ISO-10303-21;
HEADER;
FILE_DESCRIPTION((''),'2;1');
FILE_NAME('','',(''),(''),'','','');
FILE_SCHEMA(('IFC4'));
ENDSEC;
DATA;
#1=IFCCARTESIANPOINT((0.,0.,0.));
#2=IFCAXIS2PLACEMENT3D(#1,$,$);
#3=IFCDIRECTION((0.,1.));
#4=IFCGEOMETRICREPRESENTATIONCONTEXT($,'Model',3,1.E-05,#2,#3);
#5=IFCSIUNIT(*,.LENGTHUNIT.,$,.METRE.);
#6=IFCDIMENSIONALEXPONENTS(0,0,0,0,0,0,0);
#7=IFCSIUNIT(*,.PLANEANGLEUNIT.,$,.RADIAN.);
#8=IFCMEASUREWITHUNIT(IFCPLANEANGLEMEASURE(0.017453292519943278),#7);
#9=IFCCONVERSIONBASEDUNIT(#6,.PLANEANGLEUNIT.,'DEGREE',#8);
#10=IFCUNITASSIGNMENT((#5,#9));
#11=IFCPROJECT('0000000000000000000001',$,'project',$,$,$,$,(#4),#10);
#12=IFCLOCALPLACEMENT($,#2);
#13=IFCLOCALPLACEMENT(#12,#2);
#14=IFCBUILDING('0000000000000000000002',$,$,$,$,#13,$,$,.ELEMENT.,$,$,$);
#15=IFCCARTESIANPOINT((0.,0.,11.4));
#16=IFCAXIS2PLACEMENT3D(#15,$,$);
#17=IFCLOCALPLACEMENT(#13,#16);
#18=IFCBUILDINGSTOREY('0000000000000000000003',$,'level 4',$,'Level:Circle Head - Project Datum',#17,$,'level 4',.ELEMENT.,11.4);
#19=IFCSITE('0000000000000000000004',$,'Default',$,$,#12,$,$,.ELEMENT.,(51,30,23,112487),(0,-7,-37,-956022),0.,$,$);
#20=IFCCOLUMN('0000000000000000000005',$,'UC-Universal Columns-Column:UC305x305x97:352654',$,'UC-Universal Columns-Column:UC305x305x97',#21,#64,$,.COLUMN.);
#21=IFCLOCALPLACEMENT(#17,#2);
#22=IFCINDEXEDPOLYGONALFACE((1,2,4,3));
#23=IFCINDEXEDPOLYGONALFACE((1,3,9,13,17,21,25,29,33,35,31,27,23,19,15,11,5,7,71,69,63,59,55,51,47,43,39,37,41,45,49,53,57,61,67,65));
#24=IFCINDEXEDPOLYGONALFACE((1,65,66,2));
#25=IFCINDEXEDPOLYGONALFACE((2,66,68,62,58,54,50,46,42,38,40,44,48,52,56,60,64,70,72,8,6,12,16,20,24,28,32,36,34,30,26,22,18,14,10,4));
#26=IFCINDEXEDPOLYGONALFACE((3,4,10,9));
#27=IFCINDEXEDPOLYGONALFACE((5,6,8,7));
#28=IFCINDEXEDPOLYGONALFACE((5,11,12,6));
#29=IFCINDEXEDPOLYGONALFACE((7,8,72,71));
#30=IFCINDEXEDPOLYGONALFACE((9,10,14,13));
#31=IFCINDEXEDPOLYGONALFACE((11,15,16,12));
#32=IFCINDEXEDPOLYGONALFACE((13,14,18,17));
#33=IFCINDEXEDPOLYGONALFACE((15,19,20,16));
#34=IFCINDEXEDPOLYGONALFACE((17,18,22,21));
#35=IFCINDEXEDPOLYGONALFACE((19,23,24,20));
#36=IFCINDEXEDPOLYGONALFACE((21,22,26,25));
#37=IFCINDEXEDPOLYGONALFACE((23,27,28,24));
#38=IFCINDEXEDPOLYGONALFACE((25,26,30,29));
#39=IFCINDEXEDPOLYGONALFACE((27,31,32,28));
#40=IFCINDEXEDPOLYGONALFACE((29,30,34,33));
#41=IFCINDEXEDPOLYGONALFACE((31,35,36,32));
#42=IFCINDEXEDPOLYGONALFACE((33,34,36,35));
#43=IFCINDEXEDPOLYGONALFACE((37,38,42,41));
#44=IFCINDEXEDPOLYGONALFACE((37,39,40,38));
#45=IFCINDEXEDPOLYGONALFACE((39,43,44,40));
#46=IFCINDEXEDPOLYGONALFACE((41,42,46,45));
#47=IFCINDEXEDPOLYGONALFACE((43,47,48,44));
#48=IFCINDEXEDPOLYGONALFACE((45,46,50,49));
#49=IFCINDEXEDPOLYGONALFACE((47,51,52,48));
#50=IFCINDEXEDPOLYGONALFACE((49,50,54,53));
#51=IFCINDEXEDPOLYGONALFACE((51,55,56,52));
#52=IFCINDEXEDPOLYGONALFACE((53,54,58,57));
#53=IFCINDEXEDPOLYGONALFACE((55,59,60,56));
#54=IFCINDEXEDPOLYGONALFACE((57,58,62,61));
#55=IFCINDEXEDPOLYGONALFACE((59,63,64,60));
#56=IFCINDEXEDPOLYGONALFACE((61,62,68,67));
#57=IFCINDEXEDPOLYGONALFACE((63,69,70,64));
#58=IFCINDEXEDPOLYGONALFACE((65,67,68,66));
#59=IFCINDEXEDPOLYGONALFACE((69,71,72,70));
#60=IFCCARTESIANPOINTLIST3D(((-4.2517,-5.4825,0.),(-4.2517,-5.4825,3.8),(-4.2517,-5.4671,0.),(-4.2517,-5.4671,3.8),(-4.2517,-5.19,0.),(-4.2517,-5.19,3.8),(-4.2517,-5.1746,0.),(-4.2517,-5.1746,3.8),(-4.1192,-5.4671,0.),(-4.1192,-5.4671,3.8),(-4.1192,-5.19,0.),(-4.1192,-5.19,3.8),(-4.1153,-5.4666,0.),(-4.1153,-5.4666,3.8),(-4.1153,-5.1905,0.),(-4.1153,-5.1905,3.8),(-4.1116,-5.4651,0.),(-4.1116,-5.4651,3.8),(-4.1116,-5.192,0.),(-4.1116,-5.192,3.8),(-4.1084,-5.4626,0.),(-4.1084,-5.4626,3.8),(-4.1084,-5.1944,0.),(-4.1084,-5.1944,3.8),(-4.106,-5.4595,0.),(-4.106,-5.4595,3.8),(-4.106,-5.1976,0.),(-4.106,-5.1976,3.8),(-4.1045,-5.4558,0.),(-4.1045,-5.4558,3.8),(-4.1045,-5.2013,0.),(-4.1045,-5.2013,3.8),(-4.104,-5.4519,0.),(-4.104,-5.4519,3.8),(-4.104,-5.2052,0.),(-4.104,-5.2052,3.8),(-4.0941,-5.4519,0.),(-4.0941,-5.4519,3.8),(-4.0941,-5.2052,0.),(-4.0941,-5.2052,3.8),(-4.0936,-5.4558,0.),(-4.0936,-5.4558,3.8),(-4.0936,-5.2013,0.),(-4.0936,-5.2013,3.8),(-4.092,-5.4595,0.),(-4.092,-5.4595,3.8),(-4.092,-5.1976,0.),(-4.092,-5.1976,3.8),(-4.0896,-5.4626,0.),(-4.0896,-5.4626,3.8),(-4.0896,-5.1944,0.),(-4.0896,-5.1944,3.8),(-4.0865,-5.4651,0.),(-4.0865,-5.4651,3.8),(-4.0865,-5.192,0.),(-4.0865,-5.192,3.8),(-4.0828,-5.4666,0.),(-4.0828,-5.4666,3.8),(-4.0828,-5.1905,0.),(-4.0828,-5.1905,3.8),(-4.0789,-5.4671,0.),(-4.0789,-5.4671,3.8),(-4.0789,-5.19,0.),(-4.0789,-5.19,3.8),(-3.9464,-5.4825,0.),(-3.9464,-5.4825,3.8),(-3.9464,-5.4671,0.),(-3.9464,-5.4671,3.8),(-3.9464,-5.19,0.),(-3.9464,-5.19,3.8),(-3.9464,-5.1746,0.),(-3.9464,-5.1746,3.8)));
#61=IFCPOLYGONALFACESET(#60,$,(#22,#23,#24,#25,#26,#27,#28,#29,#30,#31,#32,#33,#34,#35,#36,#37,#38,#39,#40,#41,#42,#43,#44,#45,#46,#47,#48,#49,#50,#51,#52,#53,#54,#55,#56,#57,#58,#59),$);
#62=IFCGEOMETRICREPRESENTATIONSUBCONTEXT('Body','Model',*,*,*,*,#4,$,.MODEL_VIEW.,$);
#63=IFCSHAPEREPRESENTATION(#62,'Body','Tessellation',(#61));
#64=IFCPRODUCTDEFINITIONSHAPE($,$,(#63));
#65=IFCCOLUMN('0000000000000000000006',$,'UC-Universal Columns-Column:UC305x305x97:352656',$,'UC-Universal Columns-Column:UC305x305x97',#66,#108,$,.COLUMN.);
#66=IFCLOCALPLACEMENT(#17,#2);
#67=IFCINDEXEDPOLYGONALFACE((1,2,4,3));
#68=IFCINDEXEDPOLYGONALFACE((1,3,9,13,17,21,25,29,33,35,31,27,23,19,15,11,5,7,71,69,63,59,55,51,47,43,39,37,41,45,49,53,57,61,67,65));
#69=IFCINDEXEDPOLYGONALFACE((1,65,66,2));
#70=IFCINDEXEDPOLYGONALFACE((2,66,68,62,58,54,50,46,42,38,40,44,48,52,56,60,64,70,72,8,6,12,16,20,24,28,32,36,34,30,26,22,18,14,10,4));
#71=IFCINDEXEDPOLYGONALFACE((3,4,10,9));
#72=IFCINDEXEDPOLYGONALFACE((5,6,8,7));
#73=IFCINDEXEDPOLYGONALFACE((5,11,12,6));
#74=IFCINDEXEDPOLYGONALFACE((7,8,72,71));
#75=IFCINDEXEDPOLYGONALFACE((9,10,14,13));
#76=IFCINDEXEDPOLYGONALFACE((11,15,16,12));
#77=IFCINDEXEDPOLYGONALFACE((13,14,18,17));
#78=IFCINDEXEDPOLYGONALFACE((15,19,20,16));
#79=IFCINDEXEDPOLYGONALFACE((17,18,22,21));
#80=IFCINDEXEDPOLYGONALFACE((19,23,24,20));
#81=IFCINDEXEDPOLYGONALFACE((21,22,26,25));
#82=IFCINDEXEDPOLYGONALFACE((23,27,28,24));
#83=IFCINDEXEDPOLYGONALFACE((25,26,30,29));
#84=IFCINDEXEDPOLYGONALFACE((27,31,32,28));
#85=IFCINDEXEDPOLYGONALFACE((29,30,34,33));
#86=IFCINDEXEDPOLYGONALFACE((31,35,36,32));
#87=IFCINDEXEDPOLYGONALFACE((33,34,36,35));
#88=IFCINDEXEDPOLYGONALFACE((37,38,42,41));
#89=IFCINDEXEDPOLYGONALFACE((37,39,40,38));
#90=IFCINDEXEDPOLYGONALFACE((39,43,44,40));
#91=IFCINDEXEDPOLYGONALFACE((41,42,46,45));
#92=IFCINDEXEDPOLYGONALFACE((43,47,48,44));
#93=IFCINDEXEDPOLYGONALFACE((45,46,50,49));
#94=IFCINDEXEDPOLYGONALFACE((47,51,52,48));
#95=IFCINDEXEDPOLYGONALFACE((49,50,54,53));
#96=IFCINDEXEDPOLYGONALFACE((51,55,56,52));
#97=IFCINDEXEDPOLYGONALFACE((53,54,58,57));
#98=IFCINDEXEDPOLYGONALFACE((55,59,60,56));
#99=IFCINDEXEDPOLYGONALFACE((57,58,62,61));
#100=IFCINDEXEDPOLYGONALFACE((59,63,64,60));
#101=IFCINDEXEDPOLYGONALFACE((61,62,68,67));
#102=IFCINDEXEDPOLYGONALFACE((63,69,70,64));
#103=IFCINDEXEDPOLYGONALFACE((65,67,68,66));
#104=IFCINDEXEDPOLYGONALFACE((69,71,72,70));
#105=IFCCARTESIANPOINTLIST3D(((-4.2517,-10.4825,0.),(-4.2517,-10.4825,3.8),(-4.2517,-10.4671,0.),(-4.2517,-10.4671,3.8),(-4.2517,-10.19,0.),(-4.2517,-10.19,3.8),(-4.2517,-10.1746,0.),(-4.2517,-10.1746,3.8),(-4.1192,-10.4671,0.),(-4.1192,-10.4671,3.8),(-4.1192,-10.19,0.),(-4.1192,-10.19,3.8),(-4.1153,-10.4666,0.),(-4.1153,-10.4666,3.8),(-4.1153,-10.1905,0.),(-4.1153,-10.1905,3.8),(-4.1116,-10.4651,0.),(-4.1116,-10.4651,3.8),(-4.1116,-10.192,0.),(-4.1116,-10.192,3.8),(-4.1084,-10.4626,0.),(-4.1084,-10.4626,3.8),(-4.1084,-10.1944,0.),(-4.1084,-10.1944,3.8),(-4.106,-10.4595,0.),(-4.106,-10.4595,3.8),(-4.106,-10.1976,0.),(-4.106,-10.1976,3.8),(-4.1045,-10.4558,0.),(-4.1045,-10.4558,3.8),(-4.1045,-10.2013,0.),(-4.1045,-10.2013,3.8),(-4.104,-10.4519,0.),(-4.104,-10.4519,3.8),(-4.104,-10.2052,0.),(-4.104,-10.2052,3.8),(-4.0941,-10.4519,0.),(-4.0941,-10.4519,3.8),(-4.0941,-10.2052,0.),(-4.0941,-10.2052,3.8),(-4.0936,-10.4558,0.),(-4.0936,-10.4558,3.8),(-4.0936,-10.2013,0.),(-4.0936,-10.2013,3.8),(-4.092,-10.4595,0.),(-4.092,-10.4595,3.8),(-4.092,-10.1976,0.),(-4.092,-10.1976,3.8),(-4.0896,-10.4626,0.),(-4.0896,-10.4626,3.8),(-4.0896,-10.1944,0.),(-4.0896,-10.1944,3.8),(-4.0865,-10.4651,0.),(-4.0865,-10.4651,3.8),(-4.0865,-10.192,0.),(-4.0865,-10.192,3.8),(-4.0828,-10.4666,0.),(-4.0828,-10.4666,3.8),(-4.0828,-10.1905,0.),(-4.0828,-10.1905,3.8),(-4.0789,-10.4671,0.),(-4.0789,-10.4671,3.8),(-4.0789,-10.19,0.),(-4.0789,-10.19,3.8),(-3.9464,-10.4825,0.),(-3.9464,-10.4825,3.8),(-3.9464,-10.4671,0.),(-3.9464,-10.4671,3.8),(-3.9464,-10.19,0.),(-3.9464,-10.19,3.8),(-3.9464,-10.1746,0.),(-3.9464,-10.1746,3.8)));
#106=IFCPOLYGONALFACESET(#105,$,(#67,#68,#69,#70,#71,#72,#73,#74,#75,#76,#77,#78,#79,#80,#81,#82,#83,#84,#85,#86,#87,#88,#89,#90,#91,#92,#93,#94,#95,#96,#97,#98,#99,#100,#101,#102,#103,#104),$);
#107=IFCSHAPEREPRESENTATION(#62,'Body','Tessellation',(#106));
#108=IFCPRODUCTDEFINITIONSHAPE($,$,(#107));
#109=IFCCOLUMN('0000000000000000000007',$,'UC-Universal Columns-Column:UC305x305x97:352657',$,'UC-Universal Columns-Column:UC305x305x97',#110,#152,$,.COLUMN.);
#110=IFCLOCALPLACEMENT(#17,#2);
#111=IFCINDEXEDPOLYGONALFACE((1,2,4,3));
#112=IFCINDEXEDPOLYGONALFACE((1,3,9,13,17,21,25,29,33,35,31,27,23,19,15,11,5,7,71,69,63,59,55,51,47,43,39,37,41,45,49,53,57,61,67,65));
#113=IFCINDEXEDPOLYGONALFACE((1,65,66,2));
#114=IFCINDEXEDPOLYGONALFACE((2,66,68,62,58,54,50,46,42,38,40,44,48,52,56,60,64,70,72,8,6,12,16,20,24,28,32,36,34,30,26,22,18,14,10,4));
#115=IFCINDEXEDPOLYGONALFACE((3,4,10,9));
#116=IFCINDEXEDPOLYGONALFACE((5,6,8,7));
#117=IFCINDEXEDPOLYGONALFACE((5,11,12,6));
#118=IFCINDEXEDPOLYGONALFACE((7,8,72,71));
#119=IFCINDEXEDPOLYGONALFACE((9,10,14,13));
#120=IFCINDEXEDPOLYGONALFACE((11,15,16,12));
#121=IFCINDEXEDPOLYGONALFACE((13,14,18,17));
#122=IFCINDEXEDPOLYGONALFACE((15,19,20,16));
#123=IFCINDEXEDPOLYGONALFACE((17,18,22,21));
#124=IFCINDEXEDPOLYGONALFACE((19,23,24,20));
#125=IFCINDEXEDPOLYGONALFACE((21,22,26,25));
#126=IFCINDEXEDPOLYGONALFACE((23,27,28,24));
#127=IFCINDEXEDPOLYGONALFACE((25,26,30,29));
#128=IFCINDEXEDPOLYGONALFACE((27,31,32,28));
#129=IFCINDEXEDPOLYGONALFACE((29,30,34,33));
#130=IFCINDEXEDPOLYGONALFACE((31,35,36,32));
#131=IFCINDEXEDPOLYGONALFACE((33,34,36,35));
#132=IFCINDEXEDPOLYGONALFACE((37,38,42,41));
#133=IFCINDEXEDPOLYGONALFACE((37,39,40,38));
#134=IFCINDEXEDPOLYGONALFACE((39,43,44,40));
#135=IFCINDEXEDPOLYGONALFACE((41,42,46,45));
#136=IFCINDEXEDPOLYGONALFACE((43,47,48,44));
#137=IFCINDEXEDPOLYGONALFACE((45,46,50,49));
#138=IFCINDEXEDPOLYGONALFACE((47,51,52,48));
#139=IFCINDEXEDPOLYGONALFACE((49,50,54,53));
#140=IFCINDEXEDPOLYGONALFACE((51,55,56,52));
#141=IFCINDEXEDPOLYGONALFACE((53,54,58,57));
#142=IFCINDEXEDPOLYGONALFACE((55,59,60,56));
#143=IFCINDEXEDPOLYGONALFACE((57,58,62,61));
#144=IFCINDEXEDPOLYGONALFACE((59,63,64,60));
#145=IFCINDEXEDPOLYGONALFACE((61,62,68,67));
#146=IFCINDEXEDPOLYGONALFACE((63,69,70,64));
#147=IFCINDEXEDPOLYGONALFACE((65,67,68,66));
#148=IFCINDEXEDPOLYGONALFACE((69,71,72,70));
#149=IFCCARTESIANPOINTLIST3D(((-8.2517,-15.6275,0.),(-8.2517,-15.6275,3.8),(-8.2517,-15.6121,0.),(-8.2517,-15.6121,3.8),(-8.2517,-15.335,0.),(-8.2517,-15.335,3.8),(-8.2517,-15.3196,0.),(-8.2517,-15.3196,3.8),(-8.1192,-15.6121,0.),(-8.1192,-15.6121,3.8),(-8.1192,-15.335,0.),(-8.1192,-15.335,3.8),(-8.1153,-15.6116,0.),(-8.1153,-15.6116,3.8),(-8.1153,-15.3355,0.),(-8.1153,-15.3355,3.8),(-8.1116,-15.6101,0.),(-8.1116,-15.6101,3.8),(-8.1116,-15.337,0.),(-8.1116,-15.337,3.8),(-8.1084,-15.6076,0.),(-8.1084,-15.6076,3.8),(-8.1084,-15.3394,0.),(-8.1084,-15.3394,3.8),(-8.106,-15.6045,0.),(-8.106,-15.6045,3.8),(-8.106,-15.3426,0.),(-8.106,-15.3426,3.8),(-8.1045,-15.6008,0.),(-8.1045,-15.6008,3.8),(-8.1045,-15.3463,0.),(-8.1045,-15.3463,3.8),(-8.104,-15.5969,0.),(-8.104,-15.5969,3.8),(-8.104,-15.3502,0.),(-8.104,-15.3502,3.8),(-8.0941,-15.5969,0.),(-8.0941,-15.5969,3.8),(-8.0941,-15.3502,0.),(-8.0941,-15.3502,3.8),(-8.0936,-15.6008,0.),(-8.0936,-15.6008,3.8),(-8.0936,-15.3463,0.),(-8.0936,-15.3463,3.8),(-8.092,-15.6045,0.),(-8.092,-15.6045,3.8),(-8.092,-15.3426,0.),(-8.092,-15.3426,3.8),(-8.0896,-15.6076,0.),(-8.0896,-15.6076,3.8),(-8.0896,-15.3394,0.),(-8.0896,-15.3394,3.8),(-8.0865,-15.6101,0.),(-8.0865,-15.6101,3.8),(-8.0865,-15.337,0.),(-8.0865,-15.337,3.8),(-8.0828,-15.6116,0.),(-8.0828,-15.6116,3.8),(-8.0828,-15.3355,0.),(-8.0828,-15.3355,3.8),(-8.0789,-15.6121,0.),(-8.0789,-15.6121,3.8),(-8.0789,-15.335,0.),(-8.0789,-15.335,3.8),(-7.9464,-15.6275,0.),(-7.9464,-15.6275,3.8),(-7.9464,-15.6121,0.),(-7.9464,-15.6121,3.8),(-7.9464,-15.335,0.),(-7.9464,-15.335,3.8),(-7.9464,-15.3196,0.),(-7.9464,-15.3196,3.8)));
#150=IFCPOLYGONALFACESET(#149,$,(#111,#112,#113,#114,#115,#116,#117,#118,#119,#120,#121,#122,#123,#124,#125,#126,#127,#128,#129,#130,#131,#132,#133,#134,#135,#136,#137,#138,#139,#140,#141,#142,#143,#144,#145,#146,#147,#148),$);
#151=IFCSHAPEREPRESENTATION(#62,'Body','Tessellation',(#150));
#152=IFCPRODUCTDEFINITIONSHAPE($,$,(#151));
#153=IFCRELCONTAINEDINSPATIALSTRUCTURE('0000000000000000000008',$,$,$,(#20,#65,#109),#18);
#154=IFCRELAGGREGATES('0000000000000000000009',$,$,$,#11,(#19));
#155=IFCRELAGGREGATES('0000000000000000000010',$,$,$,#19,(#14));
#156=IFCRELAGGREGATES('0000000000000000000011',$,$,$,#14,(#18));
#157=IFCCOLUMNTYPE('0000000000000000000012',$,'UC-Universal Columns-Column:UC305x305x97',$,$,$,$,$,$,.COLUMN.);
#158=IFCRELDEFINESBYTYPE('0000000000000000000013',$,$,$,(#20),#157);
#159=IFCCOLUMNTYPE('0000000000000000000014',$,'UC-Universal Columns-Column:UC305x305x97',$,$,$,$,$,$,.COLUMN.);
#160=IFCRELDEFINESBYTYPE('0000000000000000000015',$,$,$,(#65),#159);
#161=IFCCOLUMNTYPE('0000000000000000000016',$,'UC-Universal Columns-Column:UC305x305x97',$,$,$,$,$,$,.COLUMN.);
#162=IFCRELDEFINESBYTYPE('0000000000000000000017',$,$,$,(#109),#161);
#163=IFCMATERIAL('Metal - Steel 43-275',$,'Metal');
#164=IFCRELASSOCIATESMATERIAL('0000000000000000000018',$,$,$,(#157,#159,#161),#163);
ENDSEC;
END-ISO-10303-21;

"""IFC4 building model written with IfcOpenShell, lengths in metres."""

from ifc_helpers import new_model, entity, si_unit, converted_unit, direction, frame, frame_2d, origin, origin_2d_with_axis, place, context, subcontext, project, spatial, i_section, extrude, source, transform, mapped, material, material_profile, profile_set, type_object, type_shapes, element, save


model = new_model("IFC4")

# Units and contexts
model_context = context("Model", 3, precision=1e-05, world=origin(), true_north=direction((0.0, 1.0)))
body_context = subcontext(model_context, "Body", "Model", "MODEL_VIEW")
ifc_project = project(units=[si_unit("LENGTHUNIT", "METRE"), converted_unit("PLANEANGLEUNIT", "DEGREE", entity("IfcPlaneAngleMeasure", 0.017453292519943278), si_unit("PLANEANGLEUNIT", "RADIAN"), dimensions=[0, 0, 0, 0, 0, 0, 0])], contexts=[model_context])

# Site, building, storey
site_placement = place(None, origin())
site = spatial("IfcSite", under=ifc_project, at=site_placement, Name="Default", CompositionType="ELEMENT", RefLatitude=(51, 30, 23, 112487), RefLongitude=(0, -7, -37, -956022), RefElevation=0.0)
building_placement = place(site_placement, origin())
building = spatial("IfcBuilding", under=site, at=building_placement, CompositionType="ELEMENT")
storey_placement = place(building_placement, frame((0.0, 0.0, 11.4)))
storey = spatial("IfcBuildingStorey", under=building, at=storey_placement, Name="level 4", ObjectType="Level:Circle Head - Project Datum", LongName="level 4", CompositionType="ELEMENT", Elevation=11.4)

# Columns
ifc_material_1 = material(Name="Metal - Steel 43-275", Category="Metal")
ifc_material_profile_1 = material_profile(ifc_material_1, i_section(OverallWidth=0.3053, OverallDepth=0.3079, WebThickness=0.0099, FlangeThickness=0.0154, FilletRadius=0.0152, at=frame_2d((0.0, 0.0), x_axis=(1.0, 0.0))), Name="UC305x305x97")
ifc_profile_set_1 = profile_set([ifc_material_profile_1], Name="UC305x305x97")
column_type_1 = type_object("IfcColumnType", Name="UC-Universal Columns-Column:UC305x305x97", PredefinedType="COLUMN", material=ifc_profile_set_1)
shared_shape_1 = source(origin(), body_context, "Body", "SweptSolid", [
    extrude(i_section(OverallWidth=0.3053, OverallDepth=0.3079, WebThickness=0.0099, FlangeThickness=0.0154, FilletRadius=0.0152, at=frame_2d((0.0, 0.0), x_axis=(1.0, 0.0))), frame((-4.099, -5.3285, 11.4), z_axis=(0.0, 0.0, 1.0), x_axis=(-1.0, 0.0, 0.0)), (0.0, 0.0, 1.0), 3.8),
])
type_shapes(column_type_1, [shared_shape_1])
column_1_placement = place(storey_placement, frame((0.0, 0.0, -11.4)))
element("IfcColumn", 1, at=column_1_placement, inside=storey, type_object=column_type_1, Name="UC-Universal Columns-Column:UC305x305x97:352654", ObjectType="UC-Universal Columns-Column:UC305x305x97", PredefinedType="COLUMN", context=body_context, shape_type="MappedRepresentation", body=[
    mapped(shared_shape_1, transform((0.0, 0.0, 0.0), scale=1.0)),
])
column_type_2 = type_object("IfcColumnType", Name="UC-Universal Columns-Column:UC305x305x97", PredefinedType="COLUMN", material=ifc_profile_set_1)
shared_shape_2 = source(origin(), body_context, "Body", "SweptSolid", [
    extrude(i_section(OverallWidth=0.3053, OverallDepth=0.3079, WebThickness=0.0099, FlangeThickness=0.0154, FilletRadius=0.0152, at=origin_2d_with_axis()), frame((-4.099, -10.3285, 11.4), z_axis=(0.0, 0.0, 1.0), x_axis=(-1.0, 0.0, 0.0)), (0.0, 0.0, 1.0), 3.8),
])
type_shapes(column_type_2, [shared_shape_2])
column_2_placement = place(storey_placement, frame((0.0, 0.0, -11.4)))
element("IfcColumn", 2, at=column_2_placement, inside=storey, type_object=column_type_2, Name="UC-Universal Columns-Column:UC305x305x97:352656", ObjectType="UC-Universal Columns-Column:UC305x305x97", PredefinedType="COLUMN", context=body_context, shape_type="MappedRepresentation", body=[
    mapped(shared_shape_2, transform((0.0, 0.0, 0.0), scale=1.0)),
])
column_type_3 = type_object("IfcColumnType", Name="UC-Universal Columns-Column:UC305x305x97", PredefinedType="COLUMN", material=ifc_profile_set_1)
shared_shape_3 = source(origin(), body_context, "Body", "SweptSolid", [
    extrude(i_section(OverallWidth=0.3053, OverallDepth=0.3079, WebThickness=0.0099, FlangeThickness=0.0154, FilletRadius=0.0152, at=frame_2d((0.0, 0.0), x_axis=(1.0, 0.0))), frame((-8.099, -15.4735, 11.4), z_axis=(0.0, 0.0, 1.0), x_axis=(-1.0, 0.0, 0.0)), (0.0, 0.0, 1.0), 3.8),
])
type_shapes(column_type_3, [shared_shape_3])
column_3_placement = place(storey_placement, frame((0.0, 0.0, -11.4)))
element("IfcColumn", 3, at=column_3_placement, inside=storey, type_object=column_type_3, Name="UC-Universal Columns-Column:UC305x305x97:352657", ObjectType="UC-Universal Columns-Column:UC305x305x97", PredefinedType="COLUMN", context=body_context, shape_type="MappedRepresentation", body=[
    mapped(shared_shape_3, transform((0.0, 0.0, 0.0), scale=1.0)),
])

save(model, "model.ifc")
